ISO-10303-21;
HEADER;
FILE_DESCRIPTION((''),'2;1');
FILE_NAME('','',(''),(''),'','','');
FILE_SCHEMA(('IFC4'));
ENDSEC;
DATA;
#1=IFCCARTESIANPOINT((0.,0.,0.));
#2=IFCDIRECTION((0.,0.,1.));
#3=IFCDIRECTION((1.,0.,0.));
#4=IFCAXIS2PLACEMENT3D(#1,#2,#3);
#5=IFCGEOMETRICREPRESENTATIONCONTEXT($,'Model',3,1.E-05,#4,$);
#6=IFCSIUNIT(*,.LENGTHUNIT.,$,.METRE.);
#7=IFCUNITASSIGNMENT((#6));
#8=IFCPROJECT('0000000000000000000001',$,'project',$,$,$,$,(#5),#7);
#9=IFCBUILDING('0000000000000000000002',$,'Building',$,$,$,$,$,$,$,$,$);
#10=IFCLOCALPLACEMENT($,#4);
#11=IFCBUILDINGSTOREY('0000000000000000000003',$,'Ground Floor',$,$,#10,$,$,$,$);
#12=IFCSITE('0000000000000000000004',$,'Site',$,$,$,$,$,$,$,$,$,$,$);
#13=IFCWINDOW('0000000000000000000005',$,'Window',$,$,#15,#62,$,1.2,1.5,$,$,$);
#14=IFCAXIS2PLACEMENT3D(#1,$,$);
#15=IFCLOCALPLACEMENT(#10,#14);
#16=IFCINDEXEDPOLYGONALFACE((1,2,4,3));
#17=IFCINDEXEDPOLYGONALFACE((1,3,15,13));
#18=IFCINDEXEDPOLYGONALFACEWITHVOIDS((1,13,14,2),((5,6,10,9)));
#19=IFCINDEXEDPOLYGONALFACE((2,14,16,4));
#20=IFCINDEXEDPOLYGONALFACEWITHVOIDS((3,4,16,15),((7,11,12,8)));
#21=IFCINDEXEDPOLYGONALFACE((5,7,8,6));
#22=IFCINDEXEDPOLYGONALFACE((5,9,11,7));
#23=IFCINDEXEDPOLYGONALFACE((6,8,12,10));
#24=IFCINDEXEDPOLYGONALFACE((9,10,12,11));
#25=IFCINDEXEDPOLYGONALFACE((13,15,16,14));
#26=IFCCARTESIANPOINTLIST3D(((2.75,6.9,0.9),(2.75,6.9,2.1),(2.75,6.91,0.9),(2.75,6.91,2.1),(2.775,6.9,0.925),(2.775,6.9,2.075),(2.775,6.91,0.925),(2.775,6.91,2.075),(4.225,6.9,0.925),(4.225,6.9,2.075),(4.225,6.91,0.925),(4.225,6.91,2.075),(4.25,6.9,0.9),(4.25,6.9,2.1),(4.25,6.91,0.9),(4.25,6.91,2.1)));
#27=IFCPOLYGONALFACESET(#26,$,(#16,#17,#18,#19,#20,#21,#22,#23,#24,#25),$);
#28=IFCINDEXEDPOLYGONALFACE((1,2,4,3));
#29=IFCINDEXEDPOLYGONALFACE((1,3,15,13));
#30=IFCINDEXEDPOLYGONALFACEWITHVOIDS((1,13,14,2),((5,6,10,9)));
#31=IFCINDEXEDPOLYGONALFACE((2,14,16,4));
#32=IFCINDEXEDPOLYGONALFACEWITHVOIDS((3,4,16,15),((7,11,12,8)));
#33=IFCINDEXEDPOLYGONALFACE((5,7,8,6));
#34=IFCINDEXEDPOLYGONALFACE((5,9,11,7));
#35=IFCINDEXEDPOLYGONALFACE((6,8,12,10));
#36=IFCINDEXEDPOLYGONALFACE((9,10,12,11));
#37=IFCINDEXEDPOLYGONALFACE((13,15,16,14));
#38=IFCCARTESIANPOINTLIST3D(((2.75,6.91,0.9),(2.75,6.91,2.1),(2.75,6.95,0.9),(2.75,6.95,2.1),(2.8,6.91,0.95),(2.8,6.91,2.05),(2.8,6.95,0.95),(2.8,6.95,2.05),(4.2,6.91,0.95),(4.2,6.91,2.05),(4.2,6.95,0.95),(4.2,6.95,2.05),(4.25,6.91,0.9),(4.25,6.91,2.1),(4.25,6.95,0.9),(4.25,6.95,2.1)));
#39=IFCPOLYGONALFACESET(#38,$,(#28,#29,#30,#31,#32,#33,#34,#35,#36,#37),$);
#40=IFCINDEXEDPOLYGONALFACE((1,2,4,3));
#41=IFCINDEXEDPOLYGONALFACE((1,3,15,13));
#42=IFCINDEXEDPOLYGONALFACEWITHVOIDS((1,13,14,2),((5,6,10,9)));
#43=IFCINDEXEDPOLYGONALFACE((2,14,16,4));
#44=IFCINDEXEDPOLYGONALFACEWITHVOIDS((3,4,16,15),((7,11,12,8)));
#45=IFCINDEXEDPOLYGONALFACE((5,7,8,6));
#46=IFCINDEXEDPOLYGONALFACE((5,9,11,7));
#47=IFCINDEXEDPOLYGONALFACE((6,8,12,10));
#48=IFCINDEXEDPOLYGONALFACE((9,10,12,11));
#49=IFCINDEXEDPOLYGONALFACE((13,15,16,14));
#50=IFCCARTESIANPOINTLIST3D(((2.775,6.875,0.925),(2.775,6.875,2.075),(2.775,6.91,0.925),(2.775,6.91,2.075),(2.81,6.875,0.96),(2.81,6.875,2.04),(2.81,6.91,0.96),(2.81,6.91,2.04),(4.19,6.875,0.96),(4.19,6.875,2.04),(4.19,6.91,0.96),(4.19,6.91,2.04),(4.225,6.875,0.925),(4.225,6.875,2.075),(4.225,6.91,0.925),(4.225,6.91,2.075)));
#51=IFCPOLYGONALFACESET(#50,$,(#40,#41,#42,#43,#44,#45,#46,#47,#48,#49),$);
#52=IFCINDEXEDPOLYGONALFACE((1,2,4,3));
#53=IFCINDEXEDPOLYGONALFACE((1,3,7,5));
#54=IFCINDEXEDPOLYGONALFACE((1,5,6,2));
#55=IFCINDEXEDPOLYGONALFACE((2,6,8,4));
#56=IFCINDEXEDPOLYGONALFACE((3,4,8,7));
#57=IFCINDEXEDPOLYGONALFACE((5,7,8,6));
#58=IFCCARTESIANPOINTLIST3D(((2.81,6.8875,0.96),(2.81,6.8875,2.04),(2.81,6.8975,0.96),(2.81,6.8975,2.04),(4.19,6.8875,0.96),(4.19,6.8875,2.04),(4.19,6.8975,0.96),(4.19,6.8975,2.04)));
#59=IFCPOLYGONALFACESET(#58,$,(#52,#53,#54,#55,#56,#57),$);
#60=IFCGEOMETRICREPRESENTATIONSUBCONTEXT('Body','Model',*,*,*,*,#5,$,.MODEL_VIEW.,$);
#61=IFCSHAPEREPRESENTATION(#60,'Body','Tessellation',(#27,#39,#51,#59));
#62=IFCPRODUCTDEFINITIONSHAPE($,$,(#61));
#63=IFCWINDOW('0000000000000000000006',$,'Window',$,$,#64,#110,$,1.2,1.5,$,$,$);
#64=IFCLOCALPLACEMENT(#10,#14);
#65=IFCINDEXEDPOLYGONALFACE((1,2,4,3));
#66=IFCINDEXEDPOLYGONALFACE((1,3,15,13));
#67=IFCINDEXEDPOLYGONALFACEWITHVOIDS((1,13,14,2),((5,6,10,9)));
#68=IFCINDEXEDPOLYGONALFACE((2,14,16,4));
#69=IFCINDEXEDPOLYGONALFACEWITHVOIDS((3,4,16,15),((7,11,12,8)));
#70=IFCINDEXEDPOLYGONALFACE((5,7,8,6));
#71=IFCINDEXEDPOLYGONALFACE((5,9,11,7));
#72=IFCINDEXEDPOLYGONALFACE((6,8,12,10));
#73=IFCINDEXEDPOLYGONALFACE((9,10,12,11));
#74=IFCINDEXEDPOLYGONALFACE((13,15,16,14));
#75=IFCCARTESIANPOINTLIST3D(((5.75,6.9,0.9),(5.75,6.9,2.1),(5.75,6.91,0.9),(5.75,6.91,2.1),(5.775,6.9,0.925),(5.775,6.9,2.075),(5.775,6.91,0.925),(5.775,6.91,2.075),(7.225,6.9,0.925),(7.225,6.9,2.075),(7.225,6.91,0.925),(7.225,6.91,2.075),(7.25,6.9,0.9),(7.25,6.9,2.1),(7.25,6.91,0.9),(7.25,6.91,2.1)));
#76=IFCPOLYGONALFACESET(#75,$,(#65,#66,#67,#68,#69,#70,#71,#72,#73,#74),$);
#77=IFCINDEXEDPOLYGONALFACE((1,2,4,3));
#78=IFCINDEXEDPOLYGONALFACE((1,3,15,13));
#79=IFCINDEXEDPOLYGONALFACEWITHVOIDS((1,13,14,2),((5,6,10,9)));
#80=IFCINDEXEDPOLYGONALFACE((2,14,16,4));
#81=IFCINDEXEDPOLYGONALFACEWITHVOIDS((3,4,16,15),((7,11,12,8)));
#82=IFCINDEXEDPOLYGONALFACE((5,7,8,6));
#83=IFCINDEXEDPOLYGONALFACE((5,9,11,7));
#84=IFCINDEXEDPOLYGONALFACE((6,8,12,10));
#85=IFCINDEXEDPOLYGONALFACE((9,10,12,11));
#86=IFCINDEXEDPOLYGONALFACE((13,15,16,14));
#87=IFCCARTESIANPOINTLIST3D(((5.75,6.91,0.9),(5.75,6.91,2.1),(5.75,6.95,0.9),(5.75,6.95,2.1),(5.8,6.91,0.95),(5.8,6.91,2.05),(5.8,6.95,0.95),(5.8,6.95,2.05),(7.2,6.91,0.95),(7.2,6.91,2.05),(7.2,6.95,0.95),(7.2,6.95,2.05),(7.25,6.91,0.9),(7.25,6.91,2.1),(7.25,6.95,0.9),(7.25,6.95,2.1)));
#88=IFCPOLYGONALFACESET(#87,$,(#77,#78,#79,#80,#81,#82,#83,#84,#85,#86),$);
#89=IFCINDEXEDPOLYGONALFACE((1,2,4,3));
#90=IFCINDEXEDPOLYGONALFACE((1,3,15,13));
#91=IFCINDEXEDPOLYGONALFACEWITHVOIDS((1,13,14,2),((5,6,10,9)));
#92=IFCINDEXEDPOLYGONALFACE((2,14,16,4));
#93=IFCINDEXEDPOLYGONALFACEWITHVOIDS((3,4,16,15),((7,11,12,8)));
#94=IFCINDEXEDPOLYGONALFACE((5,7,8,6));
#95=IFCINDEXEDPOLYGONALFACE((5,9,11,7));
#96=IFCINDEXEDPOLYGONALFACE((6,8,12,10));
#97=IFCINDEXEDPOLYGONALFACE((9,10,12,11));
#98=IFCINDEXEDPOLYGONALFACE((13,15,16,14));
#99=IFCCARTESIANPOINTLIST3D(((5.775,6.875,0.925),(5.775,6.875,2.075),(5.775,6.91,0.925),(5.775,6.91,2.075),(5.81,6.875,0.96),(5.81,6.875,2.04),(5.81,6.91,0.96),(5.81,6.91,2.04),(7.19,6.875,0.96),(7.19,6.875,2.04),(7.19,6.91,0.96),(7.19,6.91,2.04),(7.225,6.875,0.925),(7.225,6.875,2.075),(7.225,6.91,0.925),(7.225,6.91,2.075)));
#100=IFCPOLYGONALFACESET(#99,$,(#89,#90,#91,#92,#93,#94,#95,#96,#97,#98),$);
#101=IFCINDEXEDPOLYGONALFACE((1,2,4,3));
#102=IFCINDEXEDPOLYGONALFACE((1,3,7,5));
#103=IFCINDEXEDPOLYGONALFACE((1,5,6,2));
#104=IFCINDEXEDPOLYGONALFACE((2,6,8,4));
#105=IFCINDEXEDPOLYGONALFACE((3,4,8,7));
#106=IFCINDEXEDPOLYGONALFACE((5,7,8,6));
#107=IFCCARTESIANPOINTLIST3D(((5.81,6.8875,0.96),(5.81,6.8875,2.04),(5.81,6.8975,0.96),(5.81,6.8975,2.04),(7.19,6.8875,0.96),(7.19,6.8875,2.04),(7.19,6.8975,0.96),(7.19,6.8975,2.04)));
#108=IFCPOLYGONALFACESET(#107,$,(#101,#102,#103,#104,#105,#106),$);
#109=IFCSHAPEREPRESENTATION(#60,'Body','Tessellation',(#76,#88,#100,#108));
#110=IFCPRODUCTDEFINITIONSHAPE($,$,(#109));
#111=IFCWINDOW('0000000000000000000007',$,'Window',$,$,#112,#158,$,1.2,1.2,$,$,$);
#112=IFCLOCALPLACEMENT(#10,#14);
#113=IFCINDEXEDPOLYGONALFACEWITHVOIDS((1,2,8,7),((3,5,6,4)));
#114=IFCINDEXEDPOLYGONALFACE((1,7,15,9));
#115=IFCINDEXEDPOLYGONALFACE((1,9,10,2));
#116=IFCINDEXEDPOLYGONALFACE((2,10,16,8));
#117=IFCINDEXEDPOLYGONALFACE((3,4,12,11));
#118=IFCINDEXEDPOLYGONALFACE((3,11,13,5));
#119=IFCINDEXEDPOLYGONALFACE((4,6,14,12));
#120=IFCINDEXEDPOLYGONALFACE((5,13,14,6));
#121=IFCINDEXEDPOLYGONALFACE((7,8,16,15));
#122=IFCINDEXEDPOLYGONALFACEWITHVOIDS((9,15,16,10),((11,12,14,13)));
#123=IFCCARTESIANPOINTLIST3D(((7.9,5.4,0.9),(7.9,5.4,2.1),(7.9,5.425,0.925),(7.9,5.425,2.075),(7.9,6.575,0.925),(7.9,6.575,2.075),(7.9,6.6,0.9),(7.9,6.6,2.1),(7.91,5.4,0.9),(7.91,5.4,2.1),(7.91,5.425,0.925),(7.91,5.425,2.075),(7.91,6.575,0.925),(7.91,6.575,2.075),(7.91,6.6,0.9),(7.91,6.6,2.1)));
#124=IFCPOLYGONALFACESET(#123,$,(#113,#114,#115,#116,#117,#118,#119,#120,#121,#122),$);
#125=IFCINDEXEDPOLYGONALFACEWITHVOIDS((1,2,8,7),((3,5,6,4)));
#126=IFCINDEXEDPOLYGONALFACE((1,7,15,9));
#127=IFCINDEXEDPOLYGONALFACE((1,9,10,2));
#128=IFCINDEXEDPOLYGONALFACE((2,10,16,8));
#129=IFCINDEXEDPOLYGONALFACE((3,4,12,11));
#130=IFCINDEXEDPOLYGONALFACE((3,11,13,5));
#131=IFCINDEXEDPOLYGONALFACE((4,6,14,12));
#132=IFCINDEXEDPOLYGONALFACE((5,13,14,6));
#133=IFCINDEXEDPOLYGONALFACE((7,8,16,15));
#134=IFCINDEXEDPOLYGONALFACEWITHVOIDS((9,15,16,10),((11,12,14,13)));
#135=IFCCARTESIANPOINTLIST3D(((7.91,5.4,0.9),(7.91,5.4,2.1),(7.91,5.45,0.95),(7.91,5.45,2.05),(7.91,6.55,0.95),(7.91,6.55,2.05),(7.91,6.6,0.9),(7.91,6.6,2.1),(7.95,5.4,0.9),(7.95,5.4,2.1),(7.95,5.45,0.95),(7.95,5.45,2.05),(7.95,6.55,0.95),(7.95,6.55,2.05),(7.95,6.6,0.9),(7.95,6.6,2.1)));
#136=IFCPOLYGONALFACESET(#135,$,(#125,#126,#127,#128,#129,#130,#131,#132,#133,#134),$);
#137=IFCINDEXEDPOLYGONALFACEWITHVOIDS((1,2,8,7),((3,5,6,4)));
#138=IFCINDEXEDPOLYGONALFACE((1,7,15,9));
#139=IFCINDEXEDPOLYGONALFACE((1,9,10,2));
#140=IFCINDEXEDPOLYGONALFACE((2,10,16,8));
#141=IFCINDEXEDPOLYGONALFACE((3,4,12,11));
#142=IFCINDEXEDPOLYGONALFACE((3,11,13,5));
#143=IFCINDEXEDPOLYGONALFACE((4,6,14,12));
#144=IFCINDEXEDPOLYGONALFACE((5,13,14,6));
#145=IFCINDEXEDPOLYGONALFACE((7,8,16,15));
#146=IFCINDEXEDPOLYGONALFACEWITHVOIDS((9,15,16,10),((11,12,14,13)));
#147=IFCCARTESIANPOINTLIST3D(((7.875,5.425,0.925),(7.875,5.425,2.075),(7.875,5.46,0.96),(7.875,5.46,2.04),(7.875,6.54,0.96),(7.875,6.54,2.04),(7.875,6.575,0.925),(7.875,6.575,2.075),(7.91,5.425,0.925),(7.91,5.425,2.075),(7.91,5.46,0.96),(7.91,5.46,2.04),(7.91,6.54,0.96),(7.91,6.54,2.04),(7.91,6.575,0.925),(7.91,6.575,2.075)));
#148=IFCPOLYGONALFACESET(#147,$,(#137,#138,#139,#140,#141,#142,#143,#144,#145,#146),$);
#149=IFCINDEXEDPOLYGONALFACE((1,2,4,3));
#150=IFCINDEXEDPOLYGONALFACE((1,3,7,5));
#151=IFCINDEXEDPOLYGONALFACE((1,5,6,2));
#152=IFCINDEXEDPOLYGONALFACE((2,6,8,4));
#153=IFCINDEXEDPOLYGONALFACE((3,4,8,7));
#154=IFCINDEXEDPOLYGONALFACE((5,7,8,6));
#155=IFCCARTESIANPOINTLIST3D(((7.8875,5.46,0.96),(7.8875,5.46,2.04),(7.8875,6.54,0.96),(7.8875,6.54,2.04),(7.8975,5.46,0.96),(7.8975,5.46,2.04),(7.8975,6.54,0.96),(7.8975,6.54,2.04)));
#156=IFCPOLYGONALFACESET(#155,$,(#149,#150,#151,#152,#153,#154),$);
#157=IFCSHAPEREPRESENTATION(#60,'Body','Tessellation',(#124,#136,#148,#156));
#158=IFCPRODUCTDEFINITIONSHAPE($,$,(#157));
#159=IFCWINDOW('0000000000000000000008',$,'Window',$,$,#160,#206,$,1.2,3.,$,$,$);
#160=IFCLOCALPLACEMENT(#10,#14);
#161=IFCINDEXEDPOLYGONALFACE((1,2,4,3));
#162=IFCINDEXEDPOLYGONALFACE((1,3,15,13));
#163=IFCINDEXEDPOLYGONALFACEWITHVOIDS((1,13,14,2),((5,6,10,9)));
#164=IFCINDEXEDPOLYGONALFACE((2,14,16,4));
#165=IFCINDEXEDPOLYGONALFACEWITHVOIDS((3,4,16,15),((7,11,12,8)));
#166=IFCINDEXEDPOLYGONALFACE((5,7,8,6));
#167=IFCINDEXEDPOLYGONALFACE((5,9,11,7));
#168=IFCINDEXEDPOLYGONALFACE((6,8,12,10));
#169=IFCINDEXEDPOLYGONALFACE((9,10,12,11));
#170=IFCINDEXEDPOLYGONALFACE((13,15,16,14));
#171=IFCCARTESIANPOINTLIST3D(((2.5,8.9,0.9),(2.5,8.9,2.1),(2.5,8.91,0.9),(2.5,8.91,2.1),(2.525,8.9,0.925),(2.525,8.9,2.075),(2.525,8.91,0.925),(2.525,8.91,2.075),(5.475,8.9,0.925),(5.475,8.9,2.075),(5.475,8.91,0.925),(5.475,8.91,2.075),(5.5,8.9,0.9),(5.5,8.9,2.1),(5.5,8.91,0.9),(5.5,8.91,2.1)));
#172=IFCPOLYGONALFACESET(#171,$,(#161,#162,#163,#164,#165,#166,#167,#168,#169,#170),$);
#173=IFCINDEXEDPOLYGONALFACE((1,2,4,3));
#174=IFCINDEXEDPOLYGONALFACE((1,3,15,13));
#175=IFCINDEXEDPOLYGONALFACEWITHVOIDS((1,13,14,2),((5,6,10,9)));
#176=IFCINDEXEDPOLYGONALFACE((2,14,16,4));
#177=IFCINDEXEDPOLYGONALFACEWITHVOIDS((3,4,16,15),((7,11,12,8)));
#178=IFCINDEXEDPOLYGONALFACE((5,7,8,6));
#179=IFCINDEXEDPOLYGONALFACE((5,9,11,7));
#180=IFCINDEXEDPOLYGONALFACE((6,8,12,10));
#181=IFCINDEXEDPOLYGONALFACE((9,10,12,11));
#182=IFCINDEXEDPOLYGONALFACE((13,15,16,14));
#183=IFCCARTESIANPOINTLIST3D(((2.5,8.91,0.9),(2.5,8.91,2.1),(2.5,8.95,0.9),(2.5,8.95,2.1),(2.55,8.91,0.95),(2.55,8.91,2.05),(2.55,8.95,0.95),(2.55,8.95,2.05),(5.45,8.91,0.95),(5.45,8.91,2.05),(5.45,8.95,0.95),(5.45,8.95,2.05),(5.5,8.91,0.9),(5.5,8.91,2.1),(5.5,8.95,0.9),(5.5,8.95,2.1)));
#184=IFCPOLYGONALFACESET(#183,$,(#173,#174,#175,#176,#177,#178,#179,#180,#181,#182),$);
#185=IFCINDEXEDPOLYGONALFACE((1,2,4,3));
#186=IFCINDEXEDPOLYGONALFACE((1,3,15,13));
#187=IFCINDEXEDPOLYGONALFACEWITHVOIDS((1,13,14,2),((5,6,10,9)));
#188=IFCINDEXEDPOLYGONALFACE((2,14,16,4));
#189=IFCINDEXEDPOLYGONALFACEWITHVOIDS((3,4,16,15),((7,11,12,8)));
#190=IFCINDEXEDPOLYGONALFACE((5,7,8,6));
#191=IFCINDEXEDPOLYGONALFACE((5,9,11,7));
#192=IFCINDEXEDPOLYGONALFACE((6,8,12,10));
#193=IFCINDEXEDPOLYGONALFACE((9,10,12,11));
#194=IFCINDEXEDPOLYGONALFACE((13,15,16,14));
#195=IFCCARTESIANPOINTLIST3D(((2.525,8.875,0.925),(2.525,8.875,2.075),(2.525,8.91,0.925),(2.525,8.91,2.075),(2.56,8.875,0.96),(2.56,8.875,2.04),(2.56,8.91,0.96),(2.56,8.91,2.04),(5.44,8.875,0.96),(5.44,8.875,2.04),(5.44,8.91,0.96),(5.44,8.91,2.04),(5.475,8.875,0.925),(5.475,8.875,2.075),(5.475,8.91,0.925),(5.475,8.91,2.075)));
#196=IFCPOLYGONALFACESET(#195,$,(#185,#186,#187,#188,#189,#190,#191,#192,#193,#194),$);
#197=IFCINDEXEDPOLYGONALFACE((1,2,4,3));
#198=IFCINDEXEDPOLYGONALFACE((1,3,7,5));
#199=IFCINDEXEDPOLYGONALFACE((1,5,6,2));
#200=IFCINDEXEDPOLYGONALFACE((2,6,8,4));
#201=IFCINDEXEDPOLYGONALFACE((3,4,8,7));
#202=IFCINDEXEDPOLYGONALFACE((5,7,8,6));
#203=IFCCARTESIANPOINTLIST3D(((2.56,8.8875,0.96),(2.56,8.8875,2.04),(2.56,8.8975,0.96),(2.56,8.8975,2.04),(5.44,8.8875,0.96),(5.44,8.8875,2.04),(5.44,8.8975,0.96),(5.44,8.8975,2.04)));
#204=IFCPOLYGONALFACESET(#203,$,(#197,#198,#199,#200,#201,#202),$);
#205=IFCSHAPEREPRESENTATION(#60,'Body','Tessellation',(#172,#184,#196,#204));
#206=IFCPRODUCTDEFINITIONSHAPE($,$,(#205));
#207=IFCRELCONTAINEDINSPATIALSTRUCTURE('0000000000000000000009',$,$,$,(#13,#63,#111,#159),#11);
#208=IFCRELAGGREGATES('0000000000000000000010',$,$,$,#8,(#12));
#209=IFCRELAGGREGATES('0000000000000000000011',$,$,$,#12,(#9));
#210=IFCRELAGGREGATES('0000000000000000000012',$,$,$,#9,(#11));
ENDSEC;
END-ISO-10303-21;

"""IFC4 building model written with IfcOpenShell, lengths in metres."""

from ifc_helpers import new_model, si_unit, frame, origin_with_axes, place, context, subcontext, project, spatial, line, indexed_curve, outline, extrude, element, save


model = new_model("IFC4")

# Units and contexts
model_context = context("Model", 3, precision=1e-05, world=origin_with_axes())
body_context = subcontext(model_context, "Body", "Model", "MODEL_VIEW")
ifc_project = project(units=[si_unit("LENGTHUNIT", "METRE")], contexts=[model_context])

# Site, building, storey
site = spatial("IfcSite", under=ifc_project, Name="Site")
building = spatial("IfcBuilding", under=site, Name="Building")
storey_placement = place(None, origin_with_axes())
storey = spatial("IfcBuildingStorey", under=building, at=storey_placement, Name="Ground Floor")

# Windows
for number, where, z_axis, x_axis, name in (
    (1, (4.25, 7.0, 0.9), (0.0, 0.0, 1.0), (-1.0, 0.0, 0.0), "Window"),
    (2, (7.25, 7.0, 0.9), (0.0, 0.0, 1.0), (-1.0, 0.0, 0.0), "Window"),
):
    element("IfcWindow", number, at=place(storey_placement, frame(where, z_axis=z_axis, x_axis=x_axis)), inside=storey, Name=name, OverallHeight=1.2, OverallWidth=1.5, context=body_context, shape_type="SweptSolid", body=[
        extrude(outline(indexed_curve([(0.0, 0.0), (1.5, 0.0), (1.5, 1.2), (0.0, 1.2)], segments=[line(1, 2, 3, 4, 1)]), holes=[indexed_curve([(0.025, 0.025), (1.475, 0.025), (1.475, 1.175), (0.025, 1.175)], segments=[line(1, 2, 3, 4, 1)])]), frame((0.0, 0.09, 0.0), z_axis=(0.0, -1.0, 0.0), x_axis=(1.0, 0.0, 0.0)), (0.0, 0.0, -1.0), 0.01),
        extrude(outline(indexed_curve([(0.0, 0.0), (1.5, 0.0), (1.5, 1.2), (0.0, 1.2)], segments=[line(1, 2, 3, 4, 1)]), holes=[indexed_curve([(0.05, 0.05), (1.45, 0.05), (1.45, 1.15), (0.05, 1.15)], segments=[line(1, 2, 3, 4, 1)])]), frame((0.0, 0.05, 0.0), z_axis=(0.0, -1.0, 0.0), x_axis=(1.0, 0.0, 0.0)), (0.0, 0.0, -1.0), 0.04),
        extrude(outline(indexed_curve([(0.0, 0.0), (1.45, 0.0), (1.45, 1.15), (0.0, 1.15)], segments=[line(1, 2, 3, 4, 1)]), holes=[indexed_curve([(0.035, 0.035), (1.415, 0.035), (1.415, 1.115), (0.035, 1.115)], segments=[line(1, 2, 3, 4, 1)])]), frame((0.025, 0.09, 0.025), z_axis=(0.0, -1.0, 0.0), x_axis=(1.0, 0.0, 0.0)), (0.0, 0.0, -1.0), 0.035),
        extrude(outline(indexed_curve([(0.035, 0.035), (1.415, 0.035), (1.415, 1.115), (0.035, 1.115)], segments=[line(1, 2, 3, 4, 1)])), frame((0.025, 0.1025, 0.025), z_axis=(0.0, -1.0, 0.0), x_axis=(1.0, 0.0, 0.0)), (0.0, 0.0, -1.0), 0.01),
    ])
window_1_placement = place(storey_placement, frame((8.0, 5.4, 0.9), z_axis=(0.0, 0.0, 1.0), x_axis=(0.0, 1.0, 0.0)))
element("IfcWindow", 3, at=window_1_placement, inside=storey, Name="Window", OverallHeight=1.2, OverallWidth=1.2, context=body_context, shape_type="SweptSolid", body=[
    extrude(outline(indexed_curve([(0.0, 0.0), (1.2, 0.0), (1.2, 1.2), (0.0, 1.2)], segments=[line(1, 2, 3, 4, 1)]), holes=[indexed_curve([(0.025, 0.025), (1.175, 0.025), (1.175, 1.175), (0.025, 1.175)], segments=[line(1, 2, 3, 4, 1)])]), frame((0.0, 0.09, 0.0), z_axis=(0.0, -1.0, 0.0), x_axis=(1.0, 0.0, 0.0)), (0.0, 0.0, -1.0), 0.01),
    extrude(outline(indexed_curve([(0.0, 0.0), (1.2, 0.0), (1.2, 1.2), (0.0, 1.2)], segments=[line(1, 2, 3, 4, 1)]), holes=[indexed_curve([(0.05, 0.05), (1.15, 0.05), (1.15, 1.15), (0.05, 1.15)], segments=[line(1, 2, 3, 4, 1)])]), frame((0.0, 0.05, 0.0), z_axis=(0.0, -1.0, 0.0), x_axis=(1.0, 0.0, 0.0)), (0.0, 0.0, -1.0), 0.04),
    extrude(outline(indexed_curve([(0.0, 0.0), (1.15, 0.0), (1.15, 1.15), (0.0, 1.15)], segments=[line(1, 2, 3, 4, 1)]), holes=[indexed_curve([(0.035, 0.035), (1.115, 0.035), (1.115, 1.115), (0.035, 1.115)], segments=[line(1, 2, 3, 4, 1)])]), frame((0.025, 0.09, 0.025), z_axis=(0.0, -1.0, 0.0), x_axis=(1.0, 0.0, 0.0)), (0.0, 0.0, -1.0), 0.035),
    extrude(outline(indexed_curve([(0.035, 0.035), (1.115, 0.035), (1.115, 1.115), (0.035, 1.115)], segments=[line(1, 2, 3, 4, 1)])), frame((0.025, 0.1025, 0.025), z_axis=(0.0, -1.0, 0.0), x_axis=(1.0, 0.0, 0.0)), (0.0, 0.0, -1.0), 0.01),
])
window_2_placement = place(storey_placement, frame((5.5, 9.0, 0.9), z_axis=(0.0, 0.0, 1.0), x_axis=(-1.0, 0.0, 0.0)))
element("IfcWindow", 4, at=window_2_placement, inside=storey, Name="Window", OverallHeight=1.2, OverallWidth=3.0, context=body_context, shape_type="SweptSolid", body=[
    extrude(outline(indexed_curve([(0.0, 0.0), (3.0, 0.0), (3.0, 1.2), (0.0, 1.2)], segments=[line(1, 2, 3, 4, 1)]), holes=[indexed_curve([(0.025, 0.025), (2.975, 0.025), (2.975, 1.175), (0.025, 1.175)], segments=[line(1, 2, 3, 4, 1)])]), frame((0.0, 0.09, 0.0), z_axis=(0.0, -1.0, 0.0), x_axis=(1.0, 0.0, 0.0)), (0.0, 0.0, -1.0), 0.01),
    extrude(outline(indexed_curve([(0.0, 0.0), (3.0, 0.0), (3.0, 1.2), (0.0, 1.2)], segments=[line(1, 2, 3, 4, 1)]), holes=[indexed_curve([(0.05, 0.05), (2.95, 0.05), (2.95, 1.15), (0.05, 1.15)], segments=[line(1, 2, 3, 4, 1)])]), frame((0.0, 0.05, 0.0), z_axis=(0.0, -1.0, 0.0), x_axis=(1.0, 0.0, 0.0)), (0.0, 0.0, -1.0), 0.04),
    extrude(outline(indexed_curve([(0.0, 0.0), (2.95, 0.0), (2.95, 1.15), (0.0, 1.15)], segments=[line(1, 2, 3, 4, 1)]), holes=[indexed_curve([(0.035, 0.035), (2.915, 0.035), (2.915, 1.115), (0.035, 1.115)], segments=[line(1, 2, 3, 4, 1)])]), frame((0.025, 0.09, 0.025), z_axis=(0.0, -1.0, 0.0), x_axis=(1.0, 0.0, 0.0)), (0.0, 0.0, -1.0), 0.035),
    extrude(outline(indexed_curve([(0.035, 0.035), (2.915, 0.035), (2.915, 1.115), (0.035, 1.115)], segments=[line(1, 2, 3, 4, 1)])), frame((0.025, 0.1025, 0.025), z_axis=(0.0, -1.0, 0.0), x_axis=(1.0, 0.0, 0.0)), (0.0, 0.0, -1.0), 0.01),
])

save(model, "model.ifc")
